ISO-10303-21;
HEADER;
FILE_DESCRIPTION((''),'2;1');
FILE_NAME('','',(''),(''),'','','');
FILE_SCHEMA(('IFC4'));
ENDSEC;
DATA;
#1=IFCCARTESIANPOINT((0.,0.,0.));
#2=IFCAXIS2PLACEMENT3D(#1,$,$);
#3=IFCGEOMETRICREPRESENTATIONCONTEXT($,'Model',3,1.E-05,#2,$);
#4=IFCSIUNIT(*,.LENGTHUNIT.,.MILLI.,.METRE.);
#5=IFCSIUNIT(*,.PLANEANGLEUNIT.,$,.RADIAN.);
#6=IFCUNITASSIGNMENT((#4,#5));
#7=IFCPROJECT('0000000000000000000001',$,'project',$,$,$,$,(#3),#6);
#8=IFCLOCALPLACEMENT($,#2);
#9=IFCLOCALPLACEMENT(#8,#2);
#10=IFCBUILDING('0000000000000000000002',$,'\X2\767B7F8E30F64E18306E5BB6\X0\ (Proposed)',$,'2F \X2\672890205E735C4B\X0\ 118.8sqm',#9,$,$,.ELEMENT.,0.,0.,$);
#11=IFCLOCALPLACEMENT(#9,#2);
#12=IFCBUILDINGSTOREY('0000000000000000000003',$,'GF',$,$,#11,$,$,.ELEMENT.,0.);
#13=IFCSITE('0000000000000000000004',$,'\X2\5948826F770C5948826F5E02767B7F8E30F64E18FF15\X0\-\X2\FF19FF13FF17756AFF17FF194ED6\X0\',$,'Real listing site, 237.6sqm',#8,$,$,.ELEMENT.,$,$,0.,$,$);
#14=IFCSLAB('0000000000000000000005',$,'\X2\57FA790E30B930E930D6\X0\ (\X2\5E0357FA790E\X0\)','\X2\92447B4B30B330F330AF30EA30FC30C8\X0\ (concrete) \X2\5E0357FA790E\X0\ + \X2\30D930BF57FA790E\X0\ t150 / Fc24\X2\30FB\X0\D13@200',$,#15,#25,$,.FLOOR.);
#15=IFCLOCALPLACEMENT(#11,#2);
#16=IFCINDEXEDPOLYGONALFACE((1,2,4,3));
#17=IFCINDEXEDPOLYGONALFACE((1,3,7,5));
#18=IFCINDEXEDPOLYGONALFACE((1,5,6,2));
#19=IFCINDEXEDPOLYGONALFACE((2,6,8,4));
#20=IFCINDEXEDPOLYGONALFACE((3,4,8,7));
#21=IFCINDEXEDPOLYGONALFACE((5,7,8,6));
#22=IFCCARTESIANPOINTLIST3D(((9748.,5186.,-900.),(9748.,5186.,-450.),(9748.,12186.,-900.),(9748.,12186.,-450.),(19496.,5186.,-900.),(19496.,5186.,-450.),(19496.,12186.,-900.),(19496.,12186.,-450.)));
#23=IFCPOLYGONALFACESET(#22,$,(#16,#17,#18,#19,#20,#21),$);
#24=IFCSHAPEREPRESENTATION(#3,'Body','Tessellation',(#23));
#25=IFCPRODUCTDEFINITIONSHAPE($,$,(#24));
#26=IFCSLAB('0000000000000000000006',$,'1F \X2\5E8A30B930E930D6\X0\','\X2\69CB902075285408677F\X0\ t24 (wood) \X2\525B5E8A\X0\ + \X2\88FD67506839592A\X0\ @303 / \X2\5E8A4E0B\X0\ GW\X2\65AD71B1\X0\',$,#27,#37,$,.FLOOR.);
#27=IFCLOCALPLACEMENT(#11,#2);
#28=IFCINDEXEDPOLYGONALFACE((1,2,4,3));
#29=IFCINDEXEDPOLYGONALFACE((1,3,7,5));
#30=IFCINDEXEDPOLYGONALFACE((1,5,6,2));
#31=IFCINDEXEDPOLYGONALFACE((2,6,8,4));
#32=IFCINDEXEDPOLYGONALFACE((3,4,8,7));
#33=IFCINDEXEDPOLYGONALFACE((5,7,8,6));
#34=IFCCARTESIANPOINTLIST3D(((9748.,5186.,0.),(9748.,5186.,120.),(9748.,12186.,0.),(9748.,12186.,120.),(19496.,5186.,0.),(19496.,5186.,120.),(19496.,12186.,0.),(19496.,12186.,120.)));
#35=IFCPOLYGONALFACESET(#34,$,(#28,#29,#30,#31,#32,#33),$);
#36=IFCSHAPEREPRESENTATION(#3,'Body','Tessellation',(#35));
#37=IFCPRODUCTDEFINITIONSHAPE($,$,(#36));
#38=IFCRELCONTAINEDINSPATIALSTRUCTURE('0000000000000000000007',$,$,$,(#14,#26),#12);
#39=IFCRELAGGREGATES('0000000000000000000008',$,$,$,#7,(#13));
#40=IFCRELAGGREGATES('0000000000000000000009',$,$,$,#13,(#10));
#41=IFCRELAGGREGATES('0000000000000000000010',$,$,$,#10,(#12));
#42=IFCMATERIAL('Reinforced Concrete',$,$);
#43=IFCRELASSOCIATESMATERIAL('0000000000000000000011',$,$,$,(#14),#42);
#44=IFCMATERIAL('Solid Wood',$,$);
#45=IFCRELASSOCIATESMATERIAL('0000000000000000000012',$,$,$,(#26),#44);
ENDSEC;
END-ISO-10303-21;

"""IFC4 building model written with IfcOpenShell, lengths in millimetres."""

from ifc_helpers import new_model, si_unit, frame, frame_2d, origin, place, context, project, spatial, rectangle, extrude, material, element, save


model = new_model("IFC4")

# Units and contexts
model_context = context("Model", 3, precision=1e-05, world=origin())
ifc_project = project(units=[si_unit("LENGTHUNIT", "METRE", prefix="MILLI"), si_unit("PLANEANGLEUNIT", "RADIAN")], contexts=[model_context])

# Site, building, storey
site_placement = place(None, origin())
site = spatial("IfcSite", under=ifc_project, at=site_placement, Name="奈良県奈良市登美ヶ丘５-９３７番７９他", ObjectType="Real listing site, 237.6sqm", CompositionType="ELEMENT", RefElevation=0.0)
building_placement = place(site_placement, origin())
building = spatial("IfcBuilding", under=site, at=building_placement, Name="登美ヶ丘の家 (Proposed)", ObjectType="2F 木造平屋 118.8sqm", CompositionType="ELEMENT", ElevationOfRefHeight=0.0, ElevationOfTerrain=0.0)
storey_placement = place(building_placement, origin())
storey = spatial("IfcBuildingStorey", under=building, at=storey_placement, Name="GF", CompositionType="ELEMENT", Elevation=0.0)

# Slabs
ifc_material_1 = material(Name="Reinforced Concrete")
slab_1_placement = place(storey_placement, frame((4874.0, 2593.0, -450.0)))
element("IfcSlab", 1, at=slab_1_placement, inside=storey, material=ifc_material_1, Name="基礎スラブ (布基礎)", Description="鉄筋コンクリート (concrete) 布基礎 + ベタ基礎 t150 / Fc24・D13@200", PredefinedType="FLOOR", context=model_context, shape_type="SweptSolid", body=[
    extrude(rectangle(XDim=9748.0, YDim=7000.0, at=frame_2d((4874.0, 3500.0))), frame((4874.0, 2593.0, -450.0)), (0.0, 0.0, 1.0), 450.0),
])
ifc_material_2 = material(Name="Solid Wood")
slab_2_placement = place(storey_placement, frame((4874.0, 2593.0, 0.0)))
element("IfcSlab", 2, at=slab_2_placement, inside=storey, material=ifc_material_2, Name="1F 床スラブ", Description="構造用合板 t24 (wood) 剛床 + 製材根太 @303 / 床下 GW断熱", PredefinedType="FLOOR", context=model_context, shape_type="SweptSolid", body=[
    extrude(rectangle(XDim=9748.0, YDim=7000.0, at=frame_2d((4874.0, 3500.0))), frame((4874.0, 2593.0, 0.0)), (0.0, 0.0, 1.0), 120.0),
])

save(model, "model.ifc")
